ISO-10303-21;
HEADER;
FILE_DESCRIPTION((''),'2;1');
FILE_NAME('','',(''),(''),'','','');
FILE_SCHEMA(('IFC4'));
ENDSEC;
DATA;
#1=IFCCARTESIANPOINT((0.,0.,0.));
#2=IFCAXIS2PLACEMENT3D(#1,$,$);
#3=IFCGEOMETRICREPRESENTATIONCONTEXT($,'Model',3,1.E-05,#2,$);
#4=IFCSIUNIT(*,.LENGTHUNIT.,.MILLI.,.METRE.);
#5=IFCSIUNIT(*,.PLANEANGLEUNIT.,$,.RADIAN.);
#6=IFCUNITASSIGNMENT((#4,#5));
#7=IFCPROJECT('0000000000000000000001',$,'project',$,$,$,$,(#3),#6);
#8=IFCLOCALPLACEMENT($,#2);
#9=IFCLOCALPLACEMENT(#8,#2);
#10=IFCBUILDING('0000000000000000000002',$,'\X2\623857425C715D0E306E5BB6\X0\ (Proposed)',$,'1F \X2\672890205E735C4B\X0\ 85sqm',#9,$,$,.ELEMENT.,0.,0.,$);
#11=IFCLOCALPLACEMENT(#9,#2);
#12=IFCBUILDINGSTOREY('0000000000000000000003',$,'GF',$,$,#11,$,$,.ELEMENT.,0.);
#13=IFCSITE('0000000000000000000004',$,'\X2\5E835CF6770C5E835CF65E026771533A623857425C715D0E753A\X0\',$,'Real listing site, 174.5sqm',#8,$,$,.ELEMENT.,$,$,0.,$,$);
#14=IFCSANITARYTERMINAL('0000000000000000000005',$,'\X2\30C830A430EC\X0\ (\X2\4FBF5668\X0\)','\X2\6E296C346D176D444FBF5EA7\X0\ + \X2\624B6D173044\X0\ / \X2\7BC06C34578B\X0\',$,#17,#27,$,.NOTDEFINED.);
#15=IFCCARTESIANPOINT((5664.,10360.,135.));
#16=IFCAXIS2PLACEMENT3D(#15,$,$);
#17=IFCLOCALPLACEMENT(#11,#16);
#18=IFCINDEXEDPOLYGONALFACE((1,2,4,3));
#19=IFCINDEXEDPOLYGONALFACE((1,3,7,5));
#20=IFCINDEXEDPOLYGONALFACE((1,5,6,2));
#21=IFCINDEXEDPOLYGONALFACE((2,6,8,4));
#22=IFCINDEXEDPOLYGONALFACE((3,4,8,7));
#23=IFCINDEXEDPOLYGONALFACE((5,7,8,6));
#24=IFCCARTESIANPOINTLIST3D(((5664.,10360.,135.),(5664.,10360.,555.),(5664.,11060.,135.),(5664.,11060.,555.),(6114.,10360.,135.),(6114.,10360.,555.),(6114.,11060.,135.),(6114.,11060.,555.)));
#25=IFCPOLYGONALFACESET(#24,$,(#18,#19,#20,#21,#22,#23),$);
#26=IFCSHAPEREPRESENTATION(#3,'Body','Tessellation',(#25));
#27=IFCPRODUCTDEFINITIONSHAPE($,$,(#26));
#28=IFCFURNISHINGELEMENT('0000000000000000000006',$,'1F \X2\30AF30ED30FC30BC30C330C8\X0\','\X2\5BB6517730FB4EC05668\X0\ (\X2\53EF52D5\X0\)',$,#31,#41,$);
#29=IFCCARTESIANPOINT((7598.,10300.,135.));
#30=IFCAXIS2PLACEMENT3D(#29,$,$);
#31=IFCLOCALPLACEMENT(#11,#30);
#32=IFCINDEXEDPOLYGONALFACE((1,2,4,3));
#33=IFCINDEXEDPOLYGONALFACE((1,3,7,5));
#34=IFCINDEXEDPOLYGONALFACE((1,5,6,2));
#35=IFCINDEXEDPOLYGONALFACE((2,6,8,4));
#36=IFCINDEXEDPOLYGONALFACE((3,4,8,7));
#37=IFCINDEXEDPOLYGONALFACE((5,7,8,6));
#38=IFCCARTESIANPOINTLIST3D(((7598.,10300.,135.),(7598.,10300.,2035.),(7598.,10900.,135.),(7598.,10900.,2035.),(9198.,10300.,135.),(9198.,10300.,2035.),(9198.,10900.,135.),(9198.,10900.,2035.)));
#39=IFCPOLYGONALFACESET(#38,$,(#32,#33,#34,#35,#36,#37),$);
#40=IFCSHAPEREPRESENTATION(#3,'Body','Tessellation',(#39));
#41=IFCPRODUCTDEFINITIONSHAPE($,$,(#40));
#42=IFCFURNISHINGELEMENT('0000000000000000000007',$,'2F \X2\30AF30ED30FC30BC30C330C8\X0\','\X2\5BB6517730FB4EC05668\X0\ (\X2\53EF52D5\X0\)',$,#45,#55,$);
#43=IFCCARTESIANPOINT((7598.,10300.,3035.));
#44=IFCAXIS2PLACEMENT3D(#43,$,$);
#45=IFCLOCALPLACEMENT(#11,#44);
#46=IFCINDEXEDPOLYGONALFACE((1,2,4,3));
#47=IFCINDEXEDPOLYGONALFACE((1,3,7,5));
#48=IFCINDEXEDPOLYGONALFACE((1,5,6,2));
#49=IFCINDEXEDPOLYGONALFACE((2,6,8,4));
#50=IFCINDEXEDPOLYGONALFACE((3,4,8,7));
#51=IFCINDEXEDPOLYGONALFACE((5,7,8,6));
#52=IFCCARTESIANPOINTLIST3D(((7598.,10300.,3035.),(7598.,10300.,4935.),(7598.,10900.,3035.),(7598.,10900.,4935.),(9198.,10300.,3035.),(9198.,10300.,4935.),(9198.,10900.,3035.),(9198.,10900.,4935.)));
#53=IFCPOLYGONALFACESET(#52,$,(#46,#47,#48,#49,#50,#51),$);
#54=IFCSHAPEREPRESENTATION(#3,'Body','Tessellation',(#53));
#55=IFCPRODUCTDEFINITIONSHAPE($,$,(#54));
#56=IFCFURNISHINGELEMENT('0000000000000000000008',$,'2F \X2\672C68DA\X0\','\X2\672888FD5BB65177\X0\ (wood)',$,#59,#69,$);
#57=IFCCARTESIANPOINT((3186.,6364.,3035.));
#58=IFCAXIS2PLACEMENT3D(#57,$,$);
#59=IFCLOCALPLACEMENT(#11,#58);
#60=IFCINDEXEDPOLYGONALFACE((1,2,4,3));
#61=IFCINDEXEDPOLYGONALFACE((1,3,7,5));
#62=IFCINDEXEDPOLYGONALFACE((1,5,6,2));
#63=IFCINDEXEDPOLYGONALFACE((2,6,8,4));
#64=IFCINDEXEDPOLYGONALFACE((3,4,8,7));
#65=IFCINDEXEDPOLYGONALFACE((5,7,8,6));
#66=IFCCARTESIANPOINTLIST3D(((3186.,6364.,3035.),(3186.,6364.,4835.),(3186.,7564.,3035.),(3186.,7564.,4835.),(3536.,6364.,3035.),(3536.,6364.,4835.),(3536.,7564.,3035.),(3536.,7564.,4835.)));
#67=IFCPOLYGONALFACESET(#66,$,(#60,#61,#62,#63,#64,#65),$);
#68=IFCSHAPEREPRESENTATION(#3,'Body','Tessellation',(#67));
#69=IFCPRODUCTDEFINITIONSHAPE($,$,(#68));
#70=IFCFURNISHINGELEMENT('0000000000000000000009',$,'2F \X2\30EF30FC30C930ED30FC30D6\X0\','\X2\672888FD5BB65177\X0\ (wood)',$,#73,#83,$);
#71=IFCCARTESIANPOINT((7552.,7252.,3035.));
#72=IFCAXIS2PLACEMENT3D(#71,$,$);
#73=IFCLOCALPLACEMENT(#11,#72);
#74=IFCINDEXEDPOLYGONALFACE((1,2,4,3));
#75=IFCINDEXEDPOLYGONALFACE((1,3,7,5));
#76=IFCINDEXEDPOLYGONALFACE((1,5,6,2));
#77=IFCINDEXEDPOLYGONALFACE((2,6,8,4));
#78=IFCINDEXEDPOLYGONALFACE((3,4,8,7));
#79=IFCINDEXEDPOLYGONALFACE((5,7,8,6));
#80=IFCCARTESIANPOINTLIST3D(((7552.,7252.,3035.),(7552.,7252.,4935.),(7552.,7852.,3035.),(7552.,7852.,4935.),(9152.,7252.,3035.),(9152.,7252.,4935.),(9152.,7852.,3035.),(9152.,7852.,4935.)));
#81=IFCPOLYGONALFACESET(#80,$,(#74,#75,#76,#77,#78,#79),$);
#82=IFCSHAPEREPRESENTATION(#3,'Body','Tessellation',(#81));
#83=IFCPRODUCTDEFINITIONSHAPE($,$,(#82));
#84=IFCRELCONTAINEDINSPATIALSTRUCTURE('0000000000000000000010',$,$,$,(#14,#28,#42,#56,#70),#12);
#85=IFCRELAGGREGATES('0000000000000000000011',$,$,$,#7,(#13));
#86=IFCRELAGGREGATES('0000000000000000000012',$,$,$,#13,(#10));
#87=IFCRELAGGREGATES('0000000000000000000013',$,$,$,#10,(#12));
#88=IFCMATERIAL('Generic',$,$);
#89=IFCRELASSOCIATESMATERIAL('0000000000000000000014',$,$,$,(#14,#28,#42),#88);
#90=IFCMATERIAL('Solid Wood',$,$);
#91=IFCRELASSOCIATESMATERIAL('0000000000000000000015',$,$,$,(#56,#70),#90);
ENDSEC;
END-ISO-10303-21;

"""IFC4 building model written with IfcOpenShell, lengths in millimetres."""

from ifc_helpers import new_model, si_unit, frame, frame_2d, origin, place, context, project, spatial, rectangle, extrude, material, element, save


model = new_model("IFC4")

# Units and contexts
model_context = context("Model", 3, precision=1e-05, world=origin())
ifc_project = project(units=[si_unit("LENGTHUNIT", "METRE", prefix="MILLI"), si_unit("PLANEANGLEUNIT", "RADIAN")], contexts=[model_context])

# Site, building, storey
site_placement = place(None, origin())
site = spatial("IfcSite", under=ifc_project, at=site_placement, Name="広島県広島市東区戸坂山崎町", ObjectType="Real listing site, 174.5sqm", CompositionType="ELEMENT", RefElevation=0.0)
building_placement = place(site_placement, origin())
building = spatial("IfcBuilding", under=site, at=building_placement, Name="戸坂山崎の家 (Proposed)", ObjectType="1F 木造平屋 85sqm", CompositionType="ELEMENT", ElevationOfRefHeight=0.0, ElevationOfTerrain=0.0)
storey_placement = place(building_placement, origin())
storey = spatial("IfcBuildingStorey", under=building, at=storey_placement, Name="GF", CompositionType="ELEMENT", Elevation=0.0)

# Shared definitions
ifc_material_1 = material(Name="Solid Wood")

# Sanitary terminal
ifc_material_2 = material(Name="Generic")
sanitary_terminal_1_placement = place(storey_placement, frame((5664.0, 10360.0, 135.0)))
element("IfcSanitaryTerminal", 1, at=sanitary_terminal_1_placement, inside=storey, material=ifc_material_2, Name="トイレ (便器)", Description="温水洗浄便座 + 手洗い / 節水型", PredefinedType="NOTDEFINED", context=model_context, shape_type="SweptSolid", body=[
    extrude(rectangle(XDim=450.0, YDim=700.0, at=frame_2d((225.0, 350.0))), frame((5664.0, 10360.0, 135.0)), (0.0, 0.0, 1.0), 420.0),
])

# Furnishing elements
furnishing_1_placement = place(storey_placement, frame((7598.0, 10300.0, 135.0)))
element("IfcFurnishingElement", 2, at=furnishing_1_placement, inside=storey, material=ifc_material_2, Name="1F クローゼット", Description="家具・什器 (可動)", context=model_context, shape_type="SweptSolid", body=[
    extrude(rectangle(XDim=1600.0, YDim=600.0, at=frame_2d((800.0, 300.0))), frame((7598.0, 10300.0, 135.0)), (0.0, 0.0, 1.0), 1900.0),
])
furnishing_2_placement = place(storey_placement, frame((7598.0, 10300.0, 3035.0)))
element("IfcFurnishingElement", 3, at=furnishing_2_placement, inside=storey, material=ifc_material_2, Name="2F クローゼット", Description="家具・什器 (可動)", context=model_context, shape_type="SweptSolid", body=[
    extrude(rectangle(XDim=1600.0, YDim=600.0, at=frame_2d((800.0, 300.0))), frame((7598.0, 10300.0, 3035.0)), (0.0, 0.0, 1.0), 1900.0),
])
furnishing_3_placement = place(storey_placement, frame((3186.0, 6364.0, 3035.0)))
element("IfcFurnishingElement", 4, at=furnishing_3_placement, inside=storey, material=ifc_material_1, Name="2F 本棚", Description="木製家具 (wood)", context=model_context, shape_type="SweptSolid", body=[
    extrude(rectangle(XDim=350.0, YDim=1200.0, at=frame_2d((175.0, 600.0))), frame((3186.0, 6364.0, 3035.0)), (0.0, 0.0, 1.0), 1800.0),
])
furnishing_4_placement = place(storey_placement, frame((7552.0, 7252.0, 3035.0)))
element("IfcFurnishingElement", 5, at=furnishing_4_placement, inside=storey, material=ifc_material_1, Name="2F ワードローブ", Description="木製家具 (wood)", context=model_context, shape_type="SweptSolid", body=[
    extrude(rectangle(XDim=1600.0, YDim=600.0, at=frame_2d((800.0, 300.0))), frame((7552.0, 7252.0, 3035.0)), (0.0, 0.0, 1.0), 1900.0),
])

save(model, "model.ifc")
